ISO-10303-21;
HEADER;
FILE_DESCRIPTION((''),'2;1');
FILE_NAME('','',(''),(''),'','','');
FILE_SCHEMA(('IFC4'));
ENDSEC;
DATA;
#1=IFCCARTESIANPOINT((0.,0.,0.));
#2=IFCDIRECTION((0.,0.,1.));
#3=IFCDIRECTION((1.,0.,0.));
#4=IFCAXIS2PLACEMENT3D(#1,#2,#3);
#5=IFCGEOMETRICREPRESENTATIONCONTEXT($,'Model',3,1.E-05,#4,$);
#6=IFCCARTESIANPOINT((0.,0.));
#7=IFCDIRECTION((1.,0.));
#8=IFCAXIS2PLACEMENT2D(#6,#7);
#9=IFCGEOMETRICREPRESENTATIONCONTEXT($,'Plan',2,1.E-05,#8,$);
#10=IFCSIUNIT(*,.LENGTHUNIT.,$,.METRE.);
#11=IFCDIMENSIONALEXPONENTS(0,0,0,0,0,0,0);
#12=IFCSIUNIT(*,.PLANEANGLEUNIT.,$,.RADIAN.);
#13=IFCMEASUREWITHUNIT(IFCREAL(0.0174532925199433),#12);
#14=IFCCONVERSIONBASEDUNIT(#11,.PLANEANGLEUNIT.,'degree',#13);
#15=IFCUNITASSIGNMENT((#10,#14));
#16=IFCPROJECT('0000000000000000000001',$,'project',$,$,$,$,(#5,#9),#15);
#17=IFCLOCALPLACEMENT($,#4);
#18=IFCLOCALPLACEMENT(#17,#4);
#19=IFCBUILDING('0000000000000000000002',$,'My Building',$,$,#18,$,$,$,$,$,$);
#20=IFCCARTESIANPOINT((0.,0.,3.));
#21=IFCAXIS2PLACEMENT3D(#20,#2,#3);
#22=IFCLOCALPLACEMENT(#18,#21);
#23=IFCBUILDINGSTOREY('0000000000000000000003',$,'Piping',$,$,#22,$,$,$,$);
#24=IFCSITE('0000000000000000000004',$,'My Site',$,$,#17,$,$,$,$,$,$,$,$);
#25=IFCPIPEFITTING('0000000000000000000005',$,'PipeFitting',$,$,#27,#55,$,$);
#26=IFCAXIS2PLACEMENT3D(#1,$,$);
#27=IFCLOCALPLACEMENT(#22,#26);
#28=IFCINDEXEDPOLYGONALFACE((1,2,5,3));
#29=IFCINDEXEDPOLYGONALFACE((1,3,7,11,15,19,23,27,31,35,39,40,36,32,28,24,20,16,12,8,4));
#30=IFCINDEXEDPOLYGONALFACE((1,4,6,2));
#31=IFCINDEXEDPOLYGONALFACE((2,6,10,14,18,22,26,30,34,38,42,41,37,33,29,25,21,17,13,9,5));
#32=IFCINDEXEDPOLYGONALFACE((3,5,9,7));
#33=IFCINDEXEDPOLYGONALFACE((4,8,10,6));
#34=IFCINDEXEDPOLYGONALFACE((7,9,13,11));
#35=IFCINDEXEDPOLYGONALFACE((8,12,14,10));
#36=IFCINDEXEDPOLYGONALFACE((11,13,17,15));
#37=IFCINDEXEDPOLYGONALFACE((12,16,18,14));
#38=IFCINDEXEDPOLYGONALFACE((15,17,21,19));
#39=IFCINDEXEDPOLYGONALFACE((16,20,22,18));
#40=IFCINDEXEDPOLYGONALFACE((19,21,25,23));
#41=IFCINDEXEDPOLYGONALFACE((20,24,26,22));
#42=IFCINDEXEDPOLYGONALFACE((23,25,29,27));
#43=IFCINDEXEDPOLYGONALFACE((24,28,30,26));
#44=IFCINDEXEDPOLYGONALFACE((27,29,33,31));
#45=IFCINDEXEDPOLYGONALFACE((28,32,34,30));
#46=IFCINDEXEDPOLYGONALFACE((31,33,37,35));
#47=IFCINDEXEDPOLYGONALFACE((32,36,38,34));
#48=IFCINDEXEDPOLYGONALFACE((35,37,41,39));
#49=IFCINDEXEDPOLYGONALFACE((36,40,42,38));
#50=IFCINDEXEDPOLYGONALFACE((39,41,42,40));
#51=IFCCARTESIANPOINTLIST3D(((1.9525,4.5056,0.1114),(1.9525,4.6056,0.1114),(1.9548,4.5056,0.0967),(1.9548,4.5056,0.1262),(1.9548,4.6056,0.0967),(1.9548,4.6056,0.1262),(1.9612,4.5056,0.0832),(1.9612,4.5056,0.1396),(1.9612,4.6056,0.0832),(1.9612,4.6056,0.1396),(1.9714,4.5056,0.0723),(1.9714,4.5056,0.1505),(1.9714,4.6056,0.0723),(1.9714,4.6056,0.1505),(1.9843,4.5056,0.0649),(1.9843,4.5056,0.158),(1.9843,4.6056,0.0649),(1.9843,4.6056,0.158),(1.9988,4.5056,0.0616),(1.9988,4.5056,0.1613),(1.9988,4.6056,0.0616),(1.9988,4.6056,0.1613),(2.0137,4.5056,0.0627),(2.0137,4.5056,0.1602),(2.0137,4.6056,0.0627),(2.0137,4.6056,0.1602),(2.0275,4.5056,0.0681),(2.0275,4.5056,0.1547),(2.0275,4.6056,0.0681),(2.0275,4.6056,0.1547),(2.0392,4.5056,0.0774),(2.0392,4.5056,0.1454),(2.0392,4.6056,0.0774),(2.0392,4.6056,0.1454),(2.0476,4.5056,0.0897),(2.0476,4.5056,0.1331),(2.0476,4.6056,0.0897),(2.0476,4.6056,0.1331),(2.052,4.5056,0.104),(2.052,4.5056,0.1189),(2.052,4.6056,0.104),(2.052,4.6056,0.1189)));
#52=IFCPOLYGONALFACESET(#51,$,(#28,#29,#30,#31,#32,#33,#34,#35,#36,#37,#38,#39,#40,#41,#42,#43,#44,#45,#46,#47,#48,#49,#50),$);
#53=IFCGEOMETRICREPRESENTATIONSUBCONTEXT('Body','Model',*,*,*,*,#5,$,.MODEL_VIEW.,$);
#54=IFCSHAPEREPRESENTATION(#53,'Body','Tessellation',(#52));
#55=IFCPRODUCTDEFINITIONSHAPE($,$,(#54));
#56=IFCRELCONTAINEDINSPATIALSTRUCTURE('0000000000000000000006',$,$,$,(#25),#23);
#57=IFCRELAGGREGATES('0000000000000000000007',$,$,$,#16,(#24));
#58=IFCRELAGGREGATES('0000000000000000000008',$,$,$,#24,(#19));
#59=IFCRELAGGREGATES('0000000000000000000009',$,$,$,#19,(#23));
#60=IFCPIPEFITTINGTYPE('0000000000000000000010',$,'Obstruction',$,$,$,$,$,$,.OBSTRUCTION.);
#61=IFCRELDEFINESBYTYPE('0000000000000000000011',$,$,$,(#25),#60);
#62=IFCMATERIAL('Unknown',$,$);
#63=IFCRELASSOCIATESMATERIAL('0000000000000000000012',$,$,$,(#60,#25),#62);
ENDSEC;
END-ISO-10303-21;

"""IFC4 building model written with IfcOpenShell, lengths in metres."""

from ifc_helpers import new_model, entity, si_unit, converted_unit, frame, origin_with_axes, origin_2d_with_axis, place, context, subcontext, project, spatial, circle, extrude, material, material_profile, profile_set, profile_usage, type_object, element, save


model = new_model("IFC4")

# Units and contexts
model_context = context("Model", 3, precision=1e-05, world=origin_with_axes())
plan_context = context("Plan", 2, precision=1e-05, world=origin_2d_with_axis())
body_context = subcontext(model_context, "Body", "Model", "MODEL_VIEW")
ifc_project = project(units=[si_unit("LENGTHUNIT", "METRE"), converted_unit("PLANEANGLEUNIT", "degree", entity("IfcReal", 0.0174532925199433), si_unit("PLANEANGLEUNIT", "RADIAN"), dimensions=[0, 0, 0, 0, 0, 0, 0])], contexts=[model_context, plan_context])

# Site, building, storey
site_placement = place(None, origin_with_axes())
site = spatial("IfcSite", under=ifc_project, at=site_placement, Name="My Site")
building_placement = place(site_placement, origin_with_axes())
building = spatial("IfcBuilding", under=site, at=building_placement, Name="My Building")
storey_placement = place(building_placement, frame((0.0, 0.0, 3.0), z_axis=(0.0, 0.0, 1.0), x_axis=(1.0, 0.0, 0.0)))
storey = spatial("IfcBuildingStorey", under=building, at=storey_placement, Name="Piping")

# Shared definitions
ifc_material = material(Name="Unknown")

# Pipe fitting
ifc_material_profile_1 = material_profile(ifc_material, circle(Radius=0.05))
ifc_profile_set_1 = profile_set([ifc_material_profile_1])
pipe_fitting_type_1 = type_object("IfcPipeFittingType", Name="Obstruction", PredefinedType="OBSTRUCTION", material=ifc_profile_set_1)
ifc_profile_usage_1 = profile_usage(ifc_profile_set_1, cardinal=16)
pipe_fitting_1_placement = place(storey_placement, frame((2.0025, 4.5056, 0.1114), z_axis=(0.0, 1.0, 0.0), x_axis=(-1.0, 0.0, 0.0)))
element("IfcPipeFitting", 1, at=pipe_fitting_1_placement, inside=storey, type_object=pipe_fitting_type_1, material=ifc_profile_usage_1, Name="PipeFitting", context=body_context, shape_type="SweptSolid", body=[
    extrude(circle(Radius=0.05), origin_with_axes(), (0.0, 0.0, 1.0), 0.1),
])

save(model, "model.ifc")
